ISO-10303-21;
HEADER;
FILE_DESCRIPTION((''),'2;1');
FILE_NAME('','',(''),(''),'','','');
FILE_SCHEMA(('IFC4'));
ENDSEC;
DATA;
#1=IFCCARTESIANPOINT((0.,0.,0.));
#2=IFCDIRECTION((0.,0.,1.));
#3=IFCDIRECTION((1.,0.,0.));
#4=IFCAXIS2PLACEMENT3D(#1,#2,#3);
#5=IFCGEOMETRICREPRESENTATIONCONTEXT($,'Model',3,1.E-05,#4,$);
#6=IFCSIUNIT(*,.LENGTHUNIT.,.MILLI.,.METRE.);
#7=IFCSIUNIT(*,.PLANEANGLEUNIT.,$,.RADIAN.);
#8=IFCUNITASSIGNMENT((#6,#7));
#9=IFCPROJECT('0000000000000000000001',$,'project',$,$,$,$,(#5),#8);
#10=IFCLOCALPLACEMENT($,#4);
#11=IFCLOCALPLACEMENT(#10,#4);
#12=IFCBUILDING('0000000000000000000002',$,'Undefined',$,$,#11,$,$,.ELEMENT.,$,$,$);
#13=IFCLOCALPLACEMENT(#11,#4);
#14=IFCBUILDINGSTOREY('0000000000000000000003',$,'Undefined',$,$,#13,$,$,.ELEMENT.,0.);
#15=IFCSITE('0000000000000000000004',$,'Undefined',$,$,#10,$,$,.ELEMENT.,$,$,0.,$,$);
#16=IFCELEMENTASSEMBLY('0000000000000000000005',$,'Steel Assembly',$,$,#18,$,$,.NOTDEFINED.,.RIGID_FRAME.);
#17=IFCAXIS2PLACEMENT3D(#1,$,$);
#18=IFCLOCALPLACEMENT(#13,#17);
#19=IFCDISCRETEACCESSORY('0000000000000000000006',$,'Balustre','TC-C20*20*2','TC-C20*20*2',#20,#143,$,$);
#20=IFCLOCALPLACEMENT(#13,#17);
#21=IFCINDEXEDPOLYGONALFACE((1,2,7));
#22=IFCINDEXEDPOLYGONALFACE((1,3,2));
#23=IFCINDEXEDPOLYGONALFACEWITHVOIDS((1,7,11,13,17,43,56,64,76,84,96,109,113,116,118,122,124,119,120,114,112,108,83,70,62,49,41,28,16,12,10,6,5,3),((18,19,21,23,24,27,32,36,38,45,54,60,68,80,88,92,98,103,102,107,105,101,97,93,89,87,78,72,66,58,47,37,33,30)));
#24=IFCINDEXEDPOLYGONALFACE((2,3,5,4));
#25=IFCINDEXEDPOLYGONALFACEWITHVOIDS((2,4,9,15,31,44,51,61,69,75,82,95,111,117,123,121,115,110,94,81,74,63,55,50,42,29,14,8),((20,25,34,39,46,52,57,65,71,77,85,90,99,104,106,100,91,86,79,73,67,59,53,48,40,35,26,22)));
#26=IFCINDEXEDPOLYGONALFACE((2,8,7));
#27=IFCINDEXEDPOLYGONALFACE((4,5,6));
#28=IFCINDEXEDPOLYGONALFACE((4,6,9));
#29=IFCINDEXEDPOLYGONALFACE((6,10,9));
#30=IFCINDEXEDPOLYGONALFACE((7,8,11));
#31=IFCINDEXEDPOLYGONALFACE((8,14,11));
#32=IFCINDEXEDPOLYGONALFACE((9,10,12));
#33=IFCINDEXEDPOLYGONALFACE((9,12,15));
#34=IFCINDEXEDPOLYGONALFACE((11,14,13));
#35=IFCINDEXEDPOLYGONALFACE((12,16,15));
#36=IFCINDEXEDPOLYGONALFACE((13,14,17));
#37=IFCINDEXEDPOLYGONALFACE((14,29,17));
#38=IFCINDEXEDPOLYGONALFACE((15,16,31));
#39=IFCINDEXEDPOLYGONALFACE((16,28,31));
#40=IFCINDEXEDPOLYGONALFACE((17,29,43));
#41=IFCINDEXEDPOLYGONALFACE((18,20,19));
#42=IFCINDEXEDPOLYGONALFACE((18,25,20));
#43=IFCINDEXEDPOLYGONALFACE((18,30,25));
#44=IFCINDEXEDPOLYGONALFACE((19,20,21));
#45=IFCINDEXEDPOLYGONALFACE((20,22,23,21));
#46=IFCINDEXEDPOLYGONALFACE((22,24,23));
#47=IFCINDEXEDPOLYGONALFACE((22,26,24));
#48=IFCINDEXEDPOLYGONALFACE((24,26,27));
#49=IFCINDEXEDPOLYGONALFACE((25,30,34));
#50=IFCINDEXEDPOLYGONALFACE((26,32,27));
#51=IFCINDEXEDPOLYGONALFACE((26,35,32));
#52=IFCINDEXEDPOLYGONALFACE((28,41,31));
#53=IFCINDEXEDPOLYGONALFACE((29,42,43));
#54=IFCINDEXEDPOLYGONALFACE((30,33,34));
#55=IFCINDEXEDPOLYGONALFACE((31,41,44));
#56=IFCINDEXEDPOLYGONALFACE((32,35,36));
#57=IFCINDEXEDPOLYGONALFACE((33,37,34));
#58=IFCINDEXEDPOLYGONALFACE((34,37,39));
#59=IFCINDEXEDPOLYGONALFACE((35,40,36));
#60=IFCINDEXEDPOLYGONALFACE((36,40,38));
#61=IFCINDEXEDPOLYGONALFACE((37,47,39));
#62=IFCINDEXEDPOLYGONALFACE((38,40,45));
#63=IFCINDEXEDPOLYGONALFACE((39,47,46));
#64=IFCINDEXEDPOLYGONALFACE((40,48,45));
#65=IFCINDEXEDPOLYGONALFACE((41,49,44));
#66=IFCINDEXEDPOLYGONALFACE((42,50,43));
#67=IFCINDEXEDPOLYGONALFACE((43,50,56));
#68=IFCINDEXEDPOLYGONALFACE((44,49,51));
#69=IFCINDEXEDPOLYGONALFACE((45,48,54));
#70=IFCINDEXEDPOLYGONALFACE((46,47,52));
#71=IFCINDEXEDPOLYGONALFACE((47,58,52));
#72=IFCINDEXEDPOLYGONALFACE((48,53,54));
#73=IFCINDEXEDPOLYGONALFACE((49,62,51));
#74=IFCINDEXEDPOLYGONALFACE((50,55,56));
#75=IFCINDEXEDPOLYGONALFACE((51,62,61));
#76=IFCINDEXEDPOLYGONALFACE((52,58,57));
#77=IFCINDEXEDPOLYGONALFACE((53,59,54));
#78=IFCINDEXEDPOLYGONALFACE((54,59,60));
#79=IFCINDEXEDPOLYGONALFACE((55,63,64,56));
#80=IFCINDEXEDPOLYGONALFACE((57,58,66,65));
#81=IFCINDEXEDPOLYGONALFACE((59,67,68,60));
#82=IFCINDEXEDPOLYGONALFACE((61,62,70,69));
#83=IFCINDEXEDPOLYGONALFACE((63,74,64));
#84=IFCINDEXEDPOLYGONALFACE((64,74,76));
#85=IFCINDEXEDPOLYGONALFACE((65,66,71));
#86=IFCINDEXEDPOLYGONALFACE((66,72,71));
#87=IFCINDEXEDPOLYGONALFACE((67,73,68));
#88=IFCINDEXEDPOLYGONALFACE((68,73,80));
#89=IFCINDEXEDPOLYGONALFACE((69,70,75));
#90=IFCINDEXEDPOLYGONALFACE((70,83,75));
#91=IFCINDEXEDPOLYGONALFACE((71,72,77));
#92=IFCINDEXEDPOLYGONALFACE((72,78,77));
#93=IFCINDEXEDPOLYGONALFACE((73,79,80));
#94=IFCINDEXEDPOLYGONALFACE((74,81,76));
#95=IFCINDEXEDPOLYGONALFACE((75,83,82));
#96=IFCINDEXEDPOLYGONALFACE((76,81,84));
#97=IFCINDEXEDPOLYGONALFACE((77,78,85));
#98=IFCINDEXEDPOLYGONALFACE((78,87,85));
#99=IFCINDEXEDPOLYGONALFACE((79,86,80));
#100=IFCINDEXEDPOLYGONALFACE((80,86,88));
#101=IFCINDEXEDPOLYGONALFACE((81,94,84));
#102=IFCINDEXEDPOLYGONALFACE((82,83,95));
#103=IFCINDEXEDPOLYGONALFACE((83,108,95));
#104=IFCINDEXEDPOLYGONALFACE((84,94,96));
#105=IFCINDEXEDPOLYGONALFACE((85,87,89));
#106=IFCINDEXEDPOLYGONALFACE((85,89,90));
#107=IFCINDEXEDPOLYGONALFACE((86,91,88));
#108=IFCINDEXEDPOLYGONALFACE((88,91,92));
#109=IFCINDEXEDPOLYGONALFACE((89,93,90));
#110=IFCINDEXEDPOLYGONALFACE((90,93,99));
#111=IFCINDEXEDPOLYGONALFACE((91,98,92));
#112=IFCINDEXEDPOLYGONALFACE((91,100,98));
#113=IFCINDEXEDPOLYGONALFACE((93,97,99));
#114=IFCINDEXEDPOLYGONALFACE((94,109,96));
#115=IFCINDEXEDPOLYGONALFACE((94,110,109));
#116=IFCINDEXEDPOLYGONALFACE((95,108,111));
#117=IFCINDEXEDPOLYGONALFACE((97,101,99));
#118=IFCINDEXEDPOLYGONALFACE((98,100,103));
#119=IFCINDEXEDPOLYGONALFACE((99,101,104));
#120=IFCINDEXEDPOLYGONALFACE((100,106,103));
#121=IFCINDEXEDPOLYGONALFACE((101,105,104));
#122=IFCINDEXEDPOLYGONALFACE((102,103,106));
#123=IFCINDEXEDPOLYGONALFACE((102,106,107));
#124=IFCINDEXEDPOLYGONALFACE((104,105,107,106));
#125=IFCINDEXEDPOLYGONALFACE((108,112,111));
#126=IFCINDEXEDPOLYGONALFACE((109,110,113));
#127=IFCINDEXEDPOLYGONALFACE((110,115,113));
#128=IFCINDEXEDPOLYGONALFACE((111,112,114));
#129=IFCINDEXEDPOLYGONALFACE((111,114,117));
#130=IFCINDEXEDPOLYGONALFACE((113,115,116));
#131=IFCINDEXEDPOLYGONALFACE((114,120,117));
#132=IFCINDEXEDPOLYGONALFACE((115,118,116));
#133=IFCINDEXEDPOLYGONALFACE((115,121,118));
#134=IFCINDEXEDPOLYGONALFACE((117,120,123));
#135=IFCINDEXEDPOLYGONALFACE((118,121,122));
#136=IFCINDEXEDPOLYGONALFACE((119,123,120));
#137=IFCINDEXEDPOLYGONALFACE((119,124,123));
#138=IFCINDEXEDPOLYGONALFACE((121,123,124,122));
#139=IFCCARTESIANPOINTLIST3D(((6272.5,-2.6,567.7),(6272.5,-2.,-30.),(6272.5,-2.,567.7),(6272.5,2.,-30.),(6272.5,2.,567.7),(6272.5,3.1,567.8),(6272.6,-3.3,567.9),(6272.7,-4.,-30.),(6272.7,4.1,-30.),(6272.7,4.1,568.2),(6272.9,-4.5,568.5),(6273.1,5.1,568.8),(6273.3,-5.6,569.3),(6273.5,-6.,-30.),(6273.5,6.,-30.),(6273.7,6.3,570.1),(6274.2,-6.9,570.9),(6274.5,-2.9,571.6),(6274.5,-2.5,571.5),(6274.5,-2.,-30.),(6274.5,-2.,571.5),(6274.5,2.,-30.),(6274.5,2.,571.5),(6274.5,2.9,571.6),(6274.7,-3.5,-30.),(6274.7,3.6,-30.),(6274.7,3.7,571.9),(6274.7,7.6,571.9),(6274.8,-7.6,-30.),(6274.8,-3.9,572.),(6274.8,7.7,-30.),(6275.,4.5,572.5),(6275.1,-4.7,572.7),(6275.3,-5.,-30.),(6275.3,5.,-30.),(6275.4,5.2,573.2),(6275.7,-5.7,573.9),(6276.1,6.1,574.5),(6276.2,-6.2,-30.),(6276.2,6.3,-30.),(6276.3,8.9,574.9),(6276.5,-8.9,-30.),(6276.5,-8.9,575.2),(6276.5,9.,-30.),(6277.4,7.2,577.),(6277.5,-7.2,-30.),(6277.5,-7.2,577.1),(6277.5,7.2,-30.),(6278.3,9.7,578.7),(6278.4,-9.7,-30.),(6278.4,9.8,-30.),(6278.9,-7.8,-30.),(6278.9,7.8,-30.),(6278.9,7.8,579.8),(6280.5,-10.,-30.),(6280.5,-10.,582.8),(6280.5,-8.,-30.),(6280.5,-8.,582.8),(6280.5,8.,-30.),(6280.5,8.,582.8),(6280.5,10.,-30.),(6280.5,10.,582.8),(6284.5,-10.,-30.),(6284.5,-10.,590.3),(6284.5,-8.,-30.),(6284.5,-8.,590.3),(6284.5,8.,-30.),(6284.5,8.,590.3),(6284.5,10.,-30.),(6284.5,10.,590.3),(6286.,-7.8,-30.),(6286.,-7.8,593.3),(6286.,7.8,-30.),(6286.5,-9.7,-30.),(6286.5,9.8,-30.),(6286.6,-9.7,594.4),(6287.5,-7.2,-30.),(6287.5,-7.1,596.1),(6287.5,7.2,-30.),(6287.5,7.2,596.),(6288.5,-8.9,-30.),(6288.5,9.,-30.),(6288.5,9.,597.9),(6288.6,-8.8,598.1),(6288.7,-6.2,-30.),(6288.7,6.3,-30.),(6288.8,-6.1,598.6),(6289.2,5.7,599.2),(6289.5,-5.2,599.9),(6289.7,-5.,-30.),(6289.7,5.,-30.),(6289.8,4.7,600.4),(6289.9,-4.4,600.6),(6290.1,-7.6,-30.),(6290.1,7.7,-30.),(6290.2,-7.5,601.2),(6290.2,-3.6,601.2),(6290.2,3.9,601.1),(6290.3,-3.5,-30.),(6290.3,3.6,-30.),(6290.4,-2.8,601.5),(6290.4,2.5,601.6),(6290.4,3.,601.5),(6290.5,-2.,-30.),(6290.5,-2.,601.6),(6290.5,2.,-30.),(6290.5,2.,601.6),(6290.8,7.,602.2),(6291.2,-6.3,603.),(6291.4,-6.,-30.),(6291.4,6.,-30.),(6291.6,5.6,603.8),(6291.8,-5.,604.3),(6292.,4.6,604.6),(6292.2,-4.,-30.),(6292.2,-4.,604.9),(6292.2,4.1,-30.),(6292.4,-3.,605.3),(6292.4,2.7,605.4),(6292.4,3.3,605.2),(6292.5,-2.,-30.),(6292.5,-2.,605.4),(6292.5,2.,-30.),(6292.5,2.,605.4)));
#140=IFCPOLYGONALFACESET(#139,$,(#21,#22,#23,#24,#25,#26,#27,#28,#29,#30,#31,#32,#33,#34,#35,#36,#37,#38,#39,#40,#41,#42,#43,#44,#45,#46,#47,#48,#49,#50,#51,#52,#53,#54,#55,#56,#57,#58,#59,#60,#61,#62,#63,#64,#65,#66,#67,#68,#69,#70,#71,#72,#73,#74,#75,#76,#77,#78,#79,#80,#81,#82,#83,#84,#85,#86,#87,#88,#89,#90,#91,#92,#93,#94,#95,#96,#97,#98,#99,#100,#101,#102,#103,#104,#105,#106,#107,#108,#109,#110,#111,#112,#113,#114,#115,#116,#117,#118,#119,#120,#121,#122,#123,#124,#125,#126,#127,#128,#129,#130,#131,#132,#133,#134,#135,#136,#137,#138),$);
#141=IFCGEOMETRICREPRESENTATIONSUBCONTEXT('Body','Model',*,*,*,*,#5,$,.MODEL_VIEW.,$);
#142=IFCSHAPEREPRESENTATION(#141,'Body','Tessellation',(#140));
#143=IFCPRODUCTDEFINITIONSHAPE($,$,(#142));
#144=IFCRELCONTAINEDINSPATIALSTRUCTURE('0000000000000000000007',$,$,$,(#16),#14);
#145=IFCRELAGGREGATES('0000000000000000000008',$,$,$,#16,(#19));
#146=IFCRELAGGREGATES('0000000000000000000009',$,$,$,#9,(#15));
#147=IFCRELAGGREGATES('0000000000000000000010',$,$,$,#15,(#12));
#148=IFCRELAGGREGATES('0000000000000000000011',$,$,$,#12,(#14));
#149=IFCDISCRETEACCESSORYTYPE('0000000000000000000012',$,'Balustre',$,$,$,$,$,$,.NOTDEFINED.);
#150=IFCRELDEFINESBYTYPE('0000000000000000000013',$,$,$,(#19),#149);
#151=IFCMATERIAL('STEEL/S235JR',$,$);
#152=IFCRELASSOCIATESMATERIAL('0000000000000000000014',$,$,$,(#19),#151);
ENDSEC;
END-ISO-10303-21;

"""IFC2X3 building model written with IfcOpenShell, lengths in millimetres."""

from ifc_helpers import new_model, si_unit, frame, origin_with_axes, origin_2d_with_axis, place, context, subcontext, project, spatial, hollow_rectangle, extrude, clip, halfspace, material, type_object, element, aggregate, save


model = new_model("IFC2X3")

# Units and contexts
model_context = context("Model", 3, precision=1e-05, world=origin_with_axes())
body_context = subcontext(model_context, "Body", "Model", "MODEL_VIEW")
ifc_project = project(units=[si_unit("LENGTHUNIT", "METRE", prefix="MILLI"), si_unit("PLANEANGLEUNIT", "RADIAN")], contexts=[model_context])

# Site, building, storey
site_placement = place(None, origin_with_axes())
site = spatial("IfcSite", under=ifc_project, at=site_placement, Name="Undefined", CompositionType="ELEMENT", RefElevation=0.0)
building_placement = place(site_placement, origin_with_axes())
building = spatial("IfcBuilding", under=site, at=building_placement, Name="Undefined", CompositionType="ELEMENT")
storey_placement = place(building_placement, origin_with_axes())
storey = spatial("IfcBuildingStorey", under=building, at=storey_placement, Name="Undefined", CompositionType="ELEMENT", Elevation=0.0)

# Element assembly
assembly_1_placement = place(storey_placement, origin_with_axes())
assembly_1 = element("IfcElementAssembly", 1, at=assembly_1_placement, inside=storey, Name="Steel Assembly", AssemblyPlace="NOTDEFINED", PredefinedType="RIGID_FRAME")
ifc_material = material(Name="STEEL/S235JR")

# Discrete accessory
discrete_accessory_type_1 = type_object("IfcDiscreteAccessoryType", Name="Balustre")
discrete_accessory_1_placement = place(assembly_1_placement, frame((6282.5, 0.0, -30.0), z_axis=(0.0, 0.0, 1.0), x_axis=(1.0, 0.0, 0.0)))
discrete_accessory_1 = element("IfcDiscreteAccessory", 2, at=discrete_accessory_1_placement, type_object=discrete_accessory_type_1, material=ifc_material, Name="Balustre", Description="TC-C20*20*2", ObjectType="TC-C20*20*2", context=body_context, shape_type="Clipping", body=[
    clip(extrude(hollow_rectangle(XDim=20.0, YDim=20.0, WallThickness=2.0, InnerFilletRadius=6.0, OuterFilletRadius=8.0, at=origin_2d_with_axis()), frame((0.0, 0.0, 635.6), z_axis=(0.0, 0.0, -1.0), x_axis=(-1.0, 0.0, 0.0)), (0.0, 0.0, 1.0), 635.6), halfspace(frame((12.4, 0.0, 640.0), z_axis=(0.883506, 0.000005, -0.46842), x_axis=(-0.000005, 1.0, 0.0)), True)),
])
aggregate(assembly_1, [discrete_accessory_1])

save(model, "model.ifc")
